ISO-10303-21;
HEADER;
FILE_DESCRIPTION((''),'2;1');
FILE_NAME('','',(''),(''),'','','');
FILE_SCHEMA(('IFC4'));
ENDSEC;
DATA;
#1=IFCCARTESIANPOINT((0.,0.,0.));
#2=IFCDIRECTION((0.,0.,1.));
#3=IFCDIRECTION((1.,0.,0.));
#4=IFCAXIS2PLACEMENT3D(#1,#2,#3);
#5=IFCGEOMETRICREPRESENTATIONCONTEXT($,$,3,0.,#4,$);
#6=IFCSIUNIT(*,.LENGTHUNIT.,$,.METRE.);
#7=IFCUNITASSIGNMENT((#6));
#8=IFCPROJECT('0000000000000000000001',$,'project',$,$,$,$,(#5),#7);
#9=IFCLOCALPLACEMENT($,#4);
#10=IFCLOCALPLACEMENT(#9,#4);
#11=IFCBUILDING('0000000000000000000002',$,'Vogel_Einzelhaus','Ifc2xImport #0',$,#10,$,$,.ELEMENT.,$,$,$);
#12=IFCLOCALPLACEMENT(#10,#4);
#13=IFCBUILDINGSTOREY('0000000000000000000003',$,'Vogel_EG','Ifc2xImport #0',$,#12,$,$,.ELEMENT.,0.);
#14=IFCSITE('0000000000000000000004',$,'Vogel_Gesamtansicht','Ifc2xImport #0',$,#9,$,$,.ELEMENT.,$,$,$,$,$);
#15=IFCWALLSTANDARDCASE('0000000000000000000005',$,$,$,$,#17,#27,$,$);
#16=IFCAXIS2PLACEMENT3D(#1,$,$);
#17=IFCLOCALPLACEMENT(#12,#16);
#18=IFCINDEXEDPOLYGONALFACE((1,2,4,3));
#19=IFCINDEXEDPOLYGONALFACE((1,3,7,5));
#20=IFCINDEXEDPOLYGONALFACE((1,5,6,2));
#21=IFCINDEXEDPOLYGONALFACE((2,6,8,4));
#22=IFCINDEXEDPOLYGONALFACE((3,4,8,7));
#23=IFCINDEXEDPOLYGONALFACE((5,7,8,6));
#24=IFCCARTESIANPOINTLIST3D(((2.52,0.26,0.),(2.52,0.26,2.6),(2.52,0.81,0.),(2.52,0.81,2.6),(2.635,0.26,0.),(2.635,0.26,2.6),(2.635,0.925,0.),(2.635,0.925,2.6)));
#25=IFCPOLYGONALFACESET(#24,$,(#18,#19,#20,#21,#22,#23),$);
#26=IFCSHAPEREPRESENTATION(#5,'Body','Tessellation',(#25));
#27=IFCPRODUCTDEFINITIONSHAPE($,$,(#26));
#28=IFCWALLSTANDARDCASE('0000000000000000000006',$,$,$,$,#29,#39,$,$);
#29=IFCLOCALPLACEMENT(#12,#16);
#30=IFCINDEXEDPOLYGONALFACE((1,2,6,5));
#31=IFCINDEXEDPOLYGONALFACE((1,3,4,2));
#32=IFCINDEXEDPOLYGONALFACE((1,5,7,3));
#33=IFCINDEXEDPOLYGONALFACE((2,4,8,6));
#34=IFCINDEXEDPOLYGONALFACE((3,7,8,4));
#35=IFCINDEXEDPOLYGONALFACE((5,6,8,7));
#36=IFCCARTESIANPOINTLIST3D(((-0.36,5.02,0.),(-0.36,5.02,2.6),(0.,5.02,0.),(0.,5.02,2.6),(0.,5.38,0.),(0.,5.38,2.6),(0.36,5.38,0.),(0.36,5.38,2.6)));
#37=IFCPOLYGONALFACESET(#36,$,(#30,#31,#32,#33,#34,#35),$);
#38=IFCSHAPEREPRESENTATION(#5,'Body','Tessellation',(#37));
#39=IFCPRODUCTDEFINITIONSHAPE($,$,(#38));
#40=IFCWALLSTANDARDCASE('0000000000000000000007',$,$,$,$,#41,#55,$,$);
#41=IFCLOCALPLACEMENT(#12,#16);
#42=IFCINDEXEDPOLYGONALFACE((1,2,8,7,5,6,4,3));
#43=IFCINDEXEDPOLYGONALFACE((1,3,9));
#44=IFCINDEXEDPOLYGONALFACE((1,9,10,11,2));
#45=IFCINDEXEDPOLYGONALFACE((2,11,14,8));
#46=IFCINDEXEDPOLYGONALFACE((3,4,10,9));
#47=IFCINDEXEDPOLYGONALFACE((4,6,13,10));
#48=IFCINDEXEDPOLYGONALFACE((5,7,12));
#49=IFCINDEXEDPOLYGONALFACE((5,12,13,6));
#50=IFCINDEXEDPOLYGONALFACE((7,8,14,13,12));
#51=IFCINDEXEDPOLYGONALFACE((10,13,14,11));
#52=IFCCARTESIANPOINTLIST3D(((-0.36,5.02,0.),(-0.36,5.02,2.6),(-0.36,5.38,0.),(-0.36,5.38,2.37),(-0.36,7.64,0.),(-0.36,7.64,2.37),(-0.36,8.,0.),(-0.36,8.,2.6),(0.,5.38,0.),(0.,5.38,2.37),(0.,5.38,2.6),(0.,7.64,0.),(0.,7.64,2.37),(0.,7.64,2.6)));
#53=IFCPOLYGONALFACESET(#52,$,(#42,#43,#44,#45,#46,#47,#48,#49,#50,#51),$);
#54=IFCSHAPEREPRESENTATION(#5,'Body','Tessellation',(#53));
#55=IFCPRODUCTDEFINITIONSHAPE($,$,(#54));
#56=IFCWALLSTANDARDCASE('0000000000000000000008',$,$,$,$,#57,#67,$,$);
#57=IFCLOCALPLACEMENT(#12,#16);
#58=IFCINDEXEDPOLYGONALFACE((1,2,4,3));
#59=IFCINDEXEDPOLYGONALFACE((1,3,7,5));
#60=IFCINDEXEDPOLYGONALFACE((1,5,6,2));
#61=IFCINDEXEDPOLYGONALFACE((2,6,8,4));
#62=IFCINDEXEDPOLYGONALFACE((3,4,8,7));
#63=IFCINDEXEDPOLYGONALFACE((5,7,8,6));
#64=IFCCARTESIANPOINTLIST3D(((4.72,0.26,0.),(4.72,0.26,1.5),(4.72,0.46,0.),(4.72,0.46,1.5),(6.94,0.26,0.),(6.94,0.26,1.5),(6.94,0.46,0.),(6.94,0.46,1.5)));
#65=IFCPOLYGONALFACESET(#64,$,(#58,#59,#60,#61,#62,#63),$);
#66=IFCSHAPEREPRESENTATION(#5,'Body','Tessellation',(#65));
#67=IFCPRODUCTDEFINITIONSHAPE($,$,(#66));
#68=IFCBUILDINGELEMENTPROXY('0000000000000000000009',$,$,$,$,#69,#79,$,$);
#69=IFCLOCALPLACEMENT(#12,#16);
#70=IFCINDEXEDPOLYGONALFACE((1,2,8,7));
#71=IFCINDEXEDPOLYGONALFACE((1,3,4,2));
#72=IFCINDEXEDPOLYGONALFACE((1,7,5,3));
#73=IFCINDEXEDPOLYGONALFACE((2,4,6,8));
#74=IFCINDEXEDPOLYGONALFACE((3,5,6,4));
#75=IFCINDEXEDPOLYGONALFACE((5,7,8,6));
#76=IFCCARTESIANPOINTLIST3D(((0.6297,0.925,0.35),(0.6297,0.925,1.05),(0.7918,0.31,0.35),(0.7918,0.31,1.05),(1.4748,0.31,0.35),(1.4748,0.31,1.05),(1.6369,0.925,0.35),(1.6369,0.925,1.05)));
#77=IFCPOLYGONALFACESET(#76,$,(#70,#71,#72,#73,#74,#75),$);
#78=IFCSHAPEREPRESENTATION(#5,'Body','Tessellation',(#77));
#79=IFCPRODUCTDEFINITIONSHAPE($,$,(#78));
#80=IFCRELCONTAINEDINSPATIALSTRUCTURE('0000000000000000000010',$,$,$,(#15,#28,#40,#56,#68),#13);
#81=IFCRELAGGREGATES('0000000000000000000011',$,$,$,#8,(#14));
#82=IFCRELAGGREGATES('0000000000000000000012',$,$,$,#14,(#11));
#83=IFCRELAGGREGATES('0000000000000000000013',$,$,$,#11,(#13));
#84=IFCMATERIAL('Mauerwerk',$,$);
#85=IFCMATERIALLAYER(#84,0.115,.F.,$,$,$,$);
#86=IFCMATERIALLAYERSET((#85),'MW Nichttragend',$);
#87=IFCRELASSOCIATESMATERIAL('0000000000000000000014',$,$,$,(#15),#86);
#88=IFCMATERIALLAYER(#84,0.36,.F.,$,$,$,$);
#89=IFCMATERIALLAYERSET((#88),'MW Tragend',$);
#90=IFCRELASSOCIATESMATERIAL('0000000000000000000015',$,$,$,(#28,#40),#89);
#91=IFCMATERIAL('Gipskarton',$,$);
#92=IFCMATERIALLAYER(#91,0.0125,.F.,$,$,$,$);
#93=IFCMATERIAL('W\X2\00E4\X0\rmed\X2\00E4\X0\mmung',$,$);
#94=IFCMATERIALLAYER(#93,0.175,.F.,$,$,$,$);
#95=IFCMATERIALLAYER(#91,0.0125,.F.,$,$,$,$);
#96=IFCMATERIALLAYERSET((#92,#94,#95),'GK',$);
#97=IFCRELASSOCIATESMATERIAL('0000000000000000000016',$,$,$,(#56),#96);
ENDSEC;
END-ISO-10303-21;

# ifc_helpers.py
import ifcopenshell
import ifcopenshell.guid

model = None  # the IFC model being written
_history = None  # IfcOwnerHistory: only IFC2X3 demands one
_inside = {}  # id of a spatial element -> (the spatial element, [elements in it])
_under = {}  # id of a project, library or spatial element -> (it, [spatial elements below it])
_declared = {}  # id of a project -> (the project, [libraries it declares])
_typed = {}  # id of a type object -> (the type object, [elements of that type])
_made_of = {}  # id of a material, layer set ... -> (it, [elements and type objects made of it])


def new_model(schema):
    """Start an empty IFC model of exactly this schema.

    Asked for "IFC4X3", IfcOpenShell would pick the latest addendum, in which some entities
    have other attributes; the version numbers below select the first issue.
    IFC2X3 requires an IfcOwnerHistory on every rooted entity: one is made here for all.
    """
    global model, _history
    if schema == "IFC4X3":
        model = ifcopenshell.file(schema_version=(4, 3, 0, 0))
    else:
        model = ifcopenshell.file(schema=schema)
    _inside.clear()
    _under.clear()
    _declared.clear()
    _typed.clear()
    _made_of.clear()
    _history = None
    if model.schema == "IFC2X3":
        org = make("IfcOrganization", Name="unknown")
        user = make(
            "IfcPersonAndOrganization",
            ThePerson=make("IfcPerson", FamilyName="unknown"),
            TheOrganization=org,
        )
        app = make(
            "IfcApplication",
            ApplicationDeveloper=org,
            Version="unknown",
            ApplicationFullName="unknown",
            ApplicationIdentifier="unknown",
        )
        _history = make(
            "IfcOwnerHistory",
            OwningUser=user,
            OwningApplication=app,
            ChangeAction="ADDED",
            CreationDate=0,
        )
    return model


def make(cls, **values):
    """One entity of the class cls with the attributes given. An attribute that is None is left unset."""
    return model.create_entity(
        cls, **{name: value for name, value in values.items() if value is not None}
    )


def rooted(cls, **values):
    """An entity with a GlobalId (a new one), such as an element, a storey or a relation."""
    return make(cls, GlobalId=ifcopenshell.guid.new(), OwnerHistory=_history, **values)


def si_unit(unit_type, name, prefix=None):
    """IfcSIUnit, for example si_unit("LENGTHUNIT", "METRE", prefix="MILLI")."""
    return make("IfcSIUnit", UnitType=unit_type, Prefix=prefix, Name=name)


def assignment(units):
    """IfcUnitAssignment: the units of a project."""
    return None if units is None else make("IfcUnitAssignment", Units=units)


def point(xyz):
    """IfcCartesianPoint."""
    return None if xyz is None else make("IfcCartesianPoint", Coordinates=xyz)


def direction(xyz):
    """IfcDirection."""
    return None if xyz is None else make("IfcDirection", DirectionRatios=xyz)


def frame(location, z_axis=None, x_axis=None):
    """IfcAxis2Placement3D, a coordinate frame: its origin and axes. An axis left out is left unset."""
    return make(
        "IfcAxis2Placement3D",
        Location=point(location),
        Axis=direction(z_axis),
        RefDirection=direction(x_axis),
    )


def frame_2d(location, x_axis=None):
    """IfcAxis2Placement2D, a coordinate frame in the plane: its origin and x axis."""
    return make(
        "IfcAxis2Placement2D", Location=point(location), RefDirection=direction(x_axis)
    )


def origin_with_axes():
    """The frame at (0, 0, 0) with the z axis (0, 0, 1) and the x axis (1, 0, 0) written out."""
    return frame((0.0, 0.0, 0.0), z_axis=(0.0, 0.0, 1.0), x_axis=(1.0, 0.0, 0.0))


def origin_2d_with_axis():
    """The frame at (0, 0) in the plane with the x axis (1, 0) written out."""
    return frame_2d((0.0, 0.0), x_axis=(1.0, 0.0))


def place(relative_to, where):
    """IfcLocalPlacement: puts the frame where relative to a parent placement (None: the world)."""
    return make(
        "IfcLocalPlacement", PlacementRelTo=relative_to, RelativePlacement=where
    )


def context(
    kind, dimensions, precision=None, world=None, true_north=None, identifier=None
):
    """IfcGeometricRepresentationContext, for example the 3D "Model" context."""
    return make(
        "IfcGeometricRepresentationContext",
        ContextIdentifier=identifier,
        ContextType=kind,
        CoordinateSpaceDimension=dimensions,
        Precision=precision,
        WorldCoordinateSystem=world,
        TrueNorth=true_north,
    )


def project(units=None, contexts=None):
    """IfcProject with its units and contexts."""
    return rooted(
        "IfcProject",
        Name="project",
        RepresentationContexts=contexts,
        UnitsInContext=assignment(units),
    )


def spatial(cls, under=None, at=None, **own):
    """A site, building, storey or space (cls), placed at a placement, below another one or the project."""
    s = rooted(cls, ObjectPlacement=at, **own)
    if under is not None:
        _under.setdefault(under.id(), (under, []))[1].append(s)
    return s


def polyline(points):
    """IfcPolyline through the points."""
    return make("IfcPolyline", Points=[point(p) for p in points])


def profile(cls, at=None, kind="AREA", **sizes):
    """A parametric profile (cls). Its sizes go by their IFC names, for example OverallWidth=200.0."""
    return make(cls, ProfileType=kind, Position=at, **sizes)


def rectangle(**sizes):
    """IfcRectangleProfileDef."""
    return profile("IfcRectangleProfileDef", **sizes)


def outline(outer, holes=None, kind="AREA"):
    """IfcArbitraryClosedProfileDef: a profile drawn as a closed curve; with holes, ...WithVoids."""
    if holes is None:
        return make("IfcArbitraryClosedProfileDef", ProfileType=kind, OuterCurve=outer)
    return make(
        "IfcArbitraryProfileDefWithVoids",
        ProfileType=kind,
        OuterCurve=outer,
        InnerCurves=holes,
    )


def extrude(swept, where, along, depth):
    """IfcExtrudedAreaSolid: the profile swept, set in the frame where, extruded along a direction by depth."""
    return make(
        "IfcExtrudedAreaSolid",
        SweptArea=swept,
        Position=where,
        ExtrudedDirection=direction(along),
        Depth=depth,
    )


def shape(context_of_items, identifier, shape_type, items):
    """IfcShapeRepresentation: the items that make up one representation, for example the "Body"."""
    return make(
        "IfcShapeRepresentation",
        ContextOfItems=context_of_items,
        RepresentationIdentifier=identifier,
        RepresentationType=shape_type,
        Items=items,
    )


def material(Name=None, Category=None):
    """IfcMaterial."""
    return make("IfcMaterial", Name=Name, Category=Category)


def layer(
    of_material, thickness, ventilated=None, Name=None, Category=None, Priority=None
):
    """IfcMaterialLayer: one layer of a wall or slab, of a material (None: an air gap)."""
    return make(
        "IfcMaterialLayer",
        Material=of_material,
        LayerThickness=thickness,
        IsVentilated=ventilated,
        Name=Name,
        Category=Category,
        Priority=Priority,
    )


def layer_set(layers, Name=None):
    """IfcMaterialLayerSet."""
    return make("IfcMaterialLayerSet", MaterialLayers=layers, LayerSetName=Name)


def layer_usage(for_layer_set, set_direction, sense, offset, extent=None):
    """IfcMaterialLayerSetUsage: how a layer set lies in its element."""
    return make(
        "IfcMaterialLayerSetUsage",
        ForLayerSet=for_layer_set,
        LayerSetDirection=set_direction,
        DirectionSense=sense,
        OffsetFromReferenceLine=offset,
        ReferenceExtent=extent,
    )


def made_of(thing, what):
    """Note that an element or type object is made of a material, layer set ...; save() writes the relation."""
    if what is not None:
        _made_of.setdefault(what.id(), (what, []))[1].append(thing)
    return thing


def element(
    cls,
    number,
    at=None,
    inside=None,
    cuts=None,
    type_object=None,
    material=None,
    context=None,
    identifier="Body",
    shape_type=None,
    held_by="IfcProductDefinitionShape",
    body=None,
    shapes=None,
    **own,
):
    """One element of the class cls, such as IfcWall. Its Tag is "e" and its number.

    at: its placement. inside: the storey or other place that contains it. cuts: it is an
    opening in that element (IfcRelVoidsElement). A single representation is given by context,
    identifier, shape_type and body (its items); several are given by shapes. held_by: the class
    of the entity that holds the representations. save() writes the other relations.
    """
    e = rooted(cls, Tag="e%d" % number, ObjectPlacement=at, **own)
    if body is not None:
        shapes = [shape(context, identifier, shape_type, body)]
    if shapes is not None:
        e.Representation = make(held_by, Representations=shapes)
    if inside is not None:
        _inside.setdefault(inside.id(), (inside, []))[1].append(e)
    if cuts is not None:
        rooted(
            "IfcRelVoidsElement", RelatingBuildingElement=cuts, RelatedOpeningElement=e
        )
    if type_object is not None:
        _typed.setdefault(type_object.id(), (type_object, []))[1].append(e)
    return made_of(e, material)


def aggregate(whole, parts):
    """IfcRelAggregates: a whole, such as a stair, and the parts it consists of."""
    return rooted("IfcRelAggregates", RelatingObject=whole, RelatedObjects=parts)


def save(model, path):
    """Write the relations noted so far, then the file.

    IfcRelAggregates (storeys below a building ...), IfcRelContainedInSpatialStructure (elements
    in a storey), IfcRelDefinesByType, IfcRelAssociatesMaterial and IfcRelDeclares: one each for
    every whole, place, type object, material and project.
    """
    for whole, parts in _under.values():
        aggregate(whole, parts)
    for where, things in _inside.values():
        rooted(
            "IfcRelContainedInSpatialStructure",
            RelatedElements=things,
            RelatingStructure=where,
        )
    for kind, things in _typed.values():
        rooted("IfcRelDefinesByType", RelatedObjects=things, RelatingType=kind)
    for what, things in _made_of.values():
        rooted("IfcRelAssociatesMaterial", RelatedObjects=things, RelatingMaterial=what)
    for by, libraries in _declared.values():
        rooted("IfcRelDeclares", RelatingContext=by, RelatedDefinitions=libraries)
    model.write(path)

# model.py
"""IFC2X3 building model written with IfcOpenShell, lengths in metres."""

from ifc_helpers import new_model, si_unit, frame, origin_with_axes, origin_2d_with_axis, place, context, project, spatial, polyline, rectangle, outline, extrude, shape, material, layer, layer_set, layer_usage, element, save


model = new_model("IFC2X3")

# Units and contexts
context_of_model = context(None, 3, precision=0.0, world=origin_with_axes())
ifc_project = project(units=[si_unit("LENGTHUNIT", "METRE")], contexts=[context_of_model])

# Site, building, storey
site_placement = place(None, origin_with_axes())
site = spatial("IfcSite", under=ifc_project, at=site_placement, Name="Vogel_Gesamtansicht", Description="Ifc2xImport #0", CompositionType="ELEMENT")
building_placement = place(site_placement, origin_with_axes())
building = spatial("IfcBuilding", under=site, at=building_placement, Name="Vogel_Einzelhaus", Description="Ifc2xImport #0", CompositionType="ELEMENT")
storey_placement = place(building_placement, origin_with_axes())
storey = spatial("IfcBuildingStorey", under=building, at=storey_placement, Name="Vogel_EG", Description="Ifc2xImport #0", CompositionType="ELEMENT", Elevation=0.0)

# Shared definitions
ifc_material_1 = material(Name="Mauerwerk")

# Shared definitions
ifc_layer_1 = layer(ifc_material_1, 0.36, ventilated=False)
ifc_layer_set_1 = layer_set([ifc_layer_1], Name="MW Tragend")

# Shared definitions
ifc_material_2 = material(Name="Gipskarton")
ifc_material_3 = material(Name="Wärmedämmung")

# Walls
ifc_layer_2 = layer(ifc_material_1, 0.115, ventilated=False)
ifc_layer_set_2 = layer_set([ifc_layer_2], Name="MW Nichttragend")
ifc_layer_usage_1 = layer_usage(ifc_layer_set_2, "AXIS2", "POSITIVE", -0.115)
wall_1_placement = place(storey_placement, frame((2.52, 0.26, 0.0), z_axis=(0.0, 0.0, 1.0), x_axis=(0.0, 1.0, 0.0)))
element("IfcWallStandardCase", 1, at=wall_1_placement, inside=storey, material=ifc_layer_usage_1, context=context_of_model, shape_type="SweptSolid", body=[
    extrude(outline(polyline([(0.665, -0.115), (0.55, 0.0), (0.0, 0.0), (0.0, -0.115), (0.665, -0.115)])), origin_with_axes(), (0.0, 0.0, 1.0), 2.6),
])
ifc_layer_usage_2 = layer_usage(ifc_layer_set_1, "AXIS2", "POSITIVE", 0.0)
wall_2_placement = place(storey_placement, frame((-0.36, 5.02, 0.0), z_axis=(0.0, 0.0, 1.0), x_axis=(1.0, 0.0, 0.0)))
element("IfcWallStandardCase", 2, at=wall_2_placement, inside=storey, material=ifc_layer_usage_2, context=context_of_model, shape_type="SweptSolid", body=[
    extrude(outline(polyline([(0.36, 0.36), (0.0, 0.0), (0.36, 0.0), (0.72, 0.36), (0.36, 0.36)])), origin_with_axes(), (0.0, 0.0, 1.0), 2.6),
])

# Wall, opening
wall_3_placement = place(storey_placement, frame((-0.36, 7.64, 0.0), z_axis=(0.0, 0.0, 1.0), x_axis=(0.0, -1.0, 0.0)))
wall_3 = element("IfcWallStandardCase", 3, at=wall_3_placement, inside=storey, material=ifc_layer_usage_2, context=context_of_model, shape_type="SweptSolid", body=[
    extrude(outline(polyline([(0.0, 0.36), (-0.36, 0.0), (2.62, 0.0), (2.26, 0.36), (0.0, 0.36)])), origin_with_axes(), (0.0, 0.0, 1.0), 2.6),
])
opening_1_placement = place(wall_3_placement, frame((0.0, 0.36, 0.0), z_axis=(1.0, 0.0, 0.0), x_axis=(0.0, 0.0, 1.0)))
element("IfcOpeningElement", 4, at=opening_1_placement, cuts=wall_3, shapes=[
    shape(context_of_model, None, "SweptSolid", [extrude(rectangle(XDim=2.37, YDim=2.26, at=origin_2d_with_axis()), frame((1.185, 0.0, 1.13), z_axis=(0.0, 1.0, 0.0), x_axis=(1.0, 0.0, 0.0)), (0.0, 0.0, 1.0), 0.36)]),
])

# Wall
ifc_layer_3 = layer(ifc_material_2, 0.0125, ventilated=False)
ifc_layer_4 = layer(ifc_material_3, 0.175, ventilated=False)
ifc_layer_5 = layer(ifc_material_2, 0.0125, ventilated=False)
ifc_layer_set_3 = layer_set([ifc_layer_3, ifc_layer_4, ifc_layer_5], Name="GK")
ifc_layer_usage_3 = layer_usage(ifc_layer_set_3, "AXIS2", "POSITIVE", 0.0)
wall_4_placement = place(storey_placement, frame((4.72, 0.26, 0.0), z_axis=(0.0, 0.0, 1.0), x_axis=(1.0, 0.0, 0.0)))
element("IfcWallStandardCase", 5, at=wall_4_placement, inside=storey, material=ifc_layer_usage_3, context=context_of_model, shape_type="SweptSolid", body=[
    extrude(outline(polyline([(0.0, 0.0), (2.22, 0.0), (2.22, 0.2), (0.0, 0.2), (0.0, 0.0)])), origin_with_axes(), (0.0, 0.0, 1.0), 1.5),
])

# Building element proxy
proxy_placement = place(storey_placement, frame((1.1333, 0.6175, 0.35), z_axis=(0.0, 0.0, 1.0), x_axis=(1.0, 0.0, 0.0)))
element("IfcBuildingElementProxy", 6, at=proxy_placement, inside=storey, context=context_of_model, shape_type="SweptSolid", body=[
    extrude(outline(polyline([(0.1621, 0.0), (0.8451, 0.0), (1.0072, 0.615), (0.0, 0.615), (0.1621, 0.0)])), frame((-0.5036, -0.3075, 0.0), z_axis=(0.0, 0.0, 1.0), x_axis=(1.0, 0.0, 0.0)), (0.0, 0.0, 1.0), 0.7),
])

save(model, "model.ifc")
